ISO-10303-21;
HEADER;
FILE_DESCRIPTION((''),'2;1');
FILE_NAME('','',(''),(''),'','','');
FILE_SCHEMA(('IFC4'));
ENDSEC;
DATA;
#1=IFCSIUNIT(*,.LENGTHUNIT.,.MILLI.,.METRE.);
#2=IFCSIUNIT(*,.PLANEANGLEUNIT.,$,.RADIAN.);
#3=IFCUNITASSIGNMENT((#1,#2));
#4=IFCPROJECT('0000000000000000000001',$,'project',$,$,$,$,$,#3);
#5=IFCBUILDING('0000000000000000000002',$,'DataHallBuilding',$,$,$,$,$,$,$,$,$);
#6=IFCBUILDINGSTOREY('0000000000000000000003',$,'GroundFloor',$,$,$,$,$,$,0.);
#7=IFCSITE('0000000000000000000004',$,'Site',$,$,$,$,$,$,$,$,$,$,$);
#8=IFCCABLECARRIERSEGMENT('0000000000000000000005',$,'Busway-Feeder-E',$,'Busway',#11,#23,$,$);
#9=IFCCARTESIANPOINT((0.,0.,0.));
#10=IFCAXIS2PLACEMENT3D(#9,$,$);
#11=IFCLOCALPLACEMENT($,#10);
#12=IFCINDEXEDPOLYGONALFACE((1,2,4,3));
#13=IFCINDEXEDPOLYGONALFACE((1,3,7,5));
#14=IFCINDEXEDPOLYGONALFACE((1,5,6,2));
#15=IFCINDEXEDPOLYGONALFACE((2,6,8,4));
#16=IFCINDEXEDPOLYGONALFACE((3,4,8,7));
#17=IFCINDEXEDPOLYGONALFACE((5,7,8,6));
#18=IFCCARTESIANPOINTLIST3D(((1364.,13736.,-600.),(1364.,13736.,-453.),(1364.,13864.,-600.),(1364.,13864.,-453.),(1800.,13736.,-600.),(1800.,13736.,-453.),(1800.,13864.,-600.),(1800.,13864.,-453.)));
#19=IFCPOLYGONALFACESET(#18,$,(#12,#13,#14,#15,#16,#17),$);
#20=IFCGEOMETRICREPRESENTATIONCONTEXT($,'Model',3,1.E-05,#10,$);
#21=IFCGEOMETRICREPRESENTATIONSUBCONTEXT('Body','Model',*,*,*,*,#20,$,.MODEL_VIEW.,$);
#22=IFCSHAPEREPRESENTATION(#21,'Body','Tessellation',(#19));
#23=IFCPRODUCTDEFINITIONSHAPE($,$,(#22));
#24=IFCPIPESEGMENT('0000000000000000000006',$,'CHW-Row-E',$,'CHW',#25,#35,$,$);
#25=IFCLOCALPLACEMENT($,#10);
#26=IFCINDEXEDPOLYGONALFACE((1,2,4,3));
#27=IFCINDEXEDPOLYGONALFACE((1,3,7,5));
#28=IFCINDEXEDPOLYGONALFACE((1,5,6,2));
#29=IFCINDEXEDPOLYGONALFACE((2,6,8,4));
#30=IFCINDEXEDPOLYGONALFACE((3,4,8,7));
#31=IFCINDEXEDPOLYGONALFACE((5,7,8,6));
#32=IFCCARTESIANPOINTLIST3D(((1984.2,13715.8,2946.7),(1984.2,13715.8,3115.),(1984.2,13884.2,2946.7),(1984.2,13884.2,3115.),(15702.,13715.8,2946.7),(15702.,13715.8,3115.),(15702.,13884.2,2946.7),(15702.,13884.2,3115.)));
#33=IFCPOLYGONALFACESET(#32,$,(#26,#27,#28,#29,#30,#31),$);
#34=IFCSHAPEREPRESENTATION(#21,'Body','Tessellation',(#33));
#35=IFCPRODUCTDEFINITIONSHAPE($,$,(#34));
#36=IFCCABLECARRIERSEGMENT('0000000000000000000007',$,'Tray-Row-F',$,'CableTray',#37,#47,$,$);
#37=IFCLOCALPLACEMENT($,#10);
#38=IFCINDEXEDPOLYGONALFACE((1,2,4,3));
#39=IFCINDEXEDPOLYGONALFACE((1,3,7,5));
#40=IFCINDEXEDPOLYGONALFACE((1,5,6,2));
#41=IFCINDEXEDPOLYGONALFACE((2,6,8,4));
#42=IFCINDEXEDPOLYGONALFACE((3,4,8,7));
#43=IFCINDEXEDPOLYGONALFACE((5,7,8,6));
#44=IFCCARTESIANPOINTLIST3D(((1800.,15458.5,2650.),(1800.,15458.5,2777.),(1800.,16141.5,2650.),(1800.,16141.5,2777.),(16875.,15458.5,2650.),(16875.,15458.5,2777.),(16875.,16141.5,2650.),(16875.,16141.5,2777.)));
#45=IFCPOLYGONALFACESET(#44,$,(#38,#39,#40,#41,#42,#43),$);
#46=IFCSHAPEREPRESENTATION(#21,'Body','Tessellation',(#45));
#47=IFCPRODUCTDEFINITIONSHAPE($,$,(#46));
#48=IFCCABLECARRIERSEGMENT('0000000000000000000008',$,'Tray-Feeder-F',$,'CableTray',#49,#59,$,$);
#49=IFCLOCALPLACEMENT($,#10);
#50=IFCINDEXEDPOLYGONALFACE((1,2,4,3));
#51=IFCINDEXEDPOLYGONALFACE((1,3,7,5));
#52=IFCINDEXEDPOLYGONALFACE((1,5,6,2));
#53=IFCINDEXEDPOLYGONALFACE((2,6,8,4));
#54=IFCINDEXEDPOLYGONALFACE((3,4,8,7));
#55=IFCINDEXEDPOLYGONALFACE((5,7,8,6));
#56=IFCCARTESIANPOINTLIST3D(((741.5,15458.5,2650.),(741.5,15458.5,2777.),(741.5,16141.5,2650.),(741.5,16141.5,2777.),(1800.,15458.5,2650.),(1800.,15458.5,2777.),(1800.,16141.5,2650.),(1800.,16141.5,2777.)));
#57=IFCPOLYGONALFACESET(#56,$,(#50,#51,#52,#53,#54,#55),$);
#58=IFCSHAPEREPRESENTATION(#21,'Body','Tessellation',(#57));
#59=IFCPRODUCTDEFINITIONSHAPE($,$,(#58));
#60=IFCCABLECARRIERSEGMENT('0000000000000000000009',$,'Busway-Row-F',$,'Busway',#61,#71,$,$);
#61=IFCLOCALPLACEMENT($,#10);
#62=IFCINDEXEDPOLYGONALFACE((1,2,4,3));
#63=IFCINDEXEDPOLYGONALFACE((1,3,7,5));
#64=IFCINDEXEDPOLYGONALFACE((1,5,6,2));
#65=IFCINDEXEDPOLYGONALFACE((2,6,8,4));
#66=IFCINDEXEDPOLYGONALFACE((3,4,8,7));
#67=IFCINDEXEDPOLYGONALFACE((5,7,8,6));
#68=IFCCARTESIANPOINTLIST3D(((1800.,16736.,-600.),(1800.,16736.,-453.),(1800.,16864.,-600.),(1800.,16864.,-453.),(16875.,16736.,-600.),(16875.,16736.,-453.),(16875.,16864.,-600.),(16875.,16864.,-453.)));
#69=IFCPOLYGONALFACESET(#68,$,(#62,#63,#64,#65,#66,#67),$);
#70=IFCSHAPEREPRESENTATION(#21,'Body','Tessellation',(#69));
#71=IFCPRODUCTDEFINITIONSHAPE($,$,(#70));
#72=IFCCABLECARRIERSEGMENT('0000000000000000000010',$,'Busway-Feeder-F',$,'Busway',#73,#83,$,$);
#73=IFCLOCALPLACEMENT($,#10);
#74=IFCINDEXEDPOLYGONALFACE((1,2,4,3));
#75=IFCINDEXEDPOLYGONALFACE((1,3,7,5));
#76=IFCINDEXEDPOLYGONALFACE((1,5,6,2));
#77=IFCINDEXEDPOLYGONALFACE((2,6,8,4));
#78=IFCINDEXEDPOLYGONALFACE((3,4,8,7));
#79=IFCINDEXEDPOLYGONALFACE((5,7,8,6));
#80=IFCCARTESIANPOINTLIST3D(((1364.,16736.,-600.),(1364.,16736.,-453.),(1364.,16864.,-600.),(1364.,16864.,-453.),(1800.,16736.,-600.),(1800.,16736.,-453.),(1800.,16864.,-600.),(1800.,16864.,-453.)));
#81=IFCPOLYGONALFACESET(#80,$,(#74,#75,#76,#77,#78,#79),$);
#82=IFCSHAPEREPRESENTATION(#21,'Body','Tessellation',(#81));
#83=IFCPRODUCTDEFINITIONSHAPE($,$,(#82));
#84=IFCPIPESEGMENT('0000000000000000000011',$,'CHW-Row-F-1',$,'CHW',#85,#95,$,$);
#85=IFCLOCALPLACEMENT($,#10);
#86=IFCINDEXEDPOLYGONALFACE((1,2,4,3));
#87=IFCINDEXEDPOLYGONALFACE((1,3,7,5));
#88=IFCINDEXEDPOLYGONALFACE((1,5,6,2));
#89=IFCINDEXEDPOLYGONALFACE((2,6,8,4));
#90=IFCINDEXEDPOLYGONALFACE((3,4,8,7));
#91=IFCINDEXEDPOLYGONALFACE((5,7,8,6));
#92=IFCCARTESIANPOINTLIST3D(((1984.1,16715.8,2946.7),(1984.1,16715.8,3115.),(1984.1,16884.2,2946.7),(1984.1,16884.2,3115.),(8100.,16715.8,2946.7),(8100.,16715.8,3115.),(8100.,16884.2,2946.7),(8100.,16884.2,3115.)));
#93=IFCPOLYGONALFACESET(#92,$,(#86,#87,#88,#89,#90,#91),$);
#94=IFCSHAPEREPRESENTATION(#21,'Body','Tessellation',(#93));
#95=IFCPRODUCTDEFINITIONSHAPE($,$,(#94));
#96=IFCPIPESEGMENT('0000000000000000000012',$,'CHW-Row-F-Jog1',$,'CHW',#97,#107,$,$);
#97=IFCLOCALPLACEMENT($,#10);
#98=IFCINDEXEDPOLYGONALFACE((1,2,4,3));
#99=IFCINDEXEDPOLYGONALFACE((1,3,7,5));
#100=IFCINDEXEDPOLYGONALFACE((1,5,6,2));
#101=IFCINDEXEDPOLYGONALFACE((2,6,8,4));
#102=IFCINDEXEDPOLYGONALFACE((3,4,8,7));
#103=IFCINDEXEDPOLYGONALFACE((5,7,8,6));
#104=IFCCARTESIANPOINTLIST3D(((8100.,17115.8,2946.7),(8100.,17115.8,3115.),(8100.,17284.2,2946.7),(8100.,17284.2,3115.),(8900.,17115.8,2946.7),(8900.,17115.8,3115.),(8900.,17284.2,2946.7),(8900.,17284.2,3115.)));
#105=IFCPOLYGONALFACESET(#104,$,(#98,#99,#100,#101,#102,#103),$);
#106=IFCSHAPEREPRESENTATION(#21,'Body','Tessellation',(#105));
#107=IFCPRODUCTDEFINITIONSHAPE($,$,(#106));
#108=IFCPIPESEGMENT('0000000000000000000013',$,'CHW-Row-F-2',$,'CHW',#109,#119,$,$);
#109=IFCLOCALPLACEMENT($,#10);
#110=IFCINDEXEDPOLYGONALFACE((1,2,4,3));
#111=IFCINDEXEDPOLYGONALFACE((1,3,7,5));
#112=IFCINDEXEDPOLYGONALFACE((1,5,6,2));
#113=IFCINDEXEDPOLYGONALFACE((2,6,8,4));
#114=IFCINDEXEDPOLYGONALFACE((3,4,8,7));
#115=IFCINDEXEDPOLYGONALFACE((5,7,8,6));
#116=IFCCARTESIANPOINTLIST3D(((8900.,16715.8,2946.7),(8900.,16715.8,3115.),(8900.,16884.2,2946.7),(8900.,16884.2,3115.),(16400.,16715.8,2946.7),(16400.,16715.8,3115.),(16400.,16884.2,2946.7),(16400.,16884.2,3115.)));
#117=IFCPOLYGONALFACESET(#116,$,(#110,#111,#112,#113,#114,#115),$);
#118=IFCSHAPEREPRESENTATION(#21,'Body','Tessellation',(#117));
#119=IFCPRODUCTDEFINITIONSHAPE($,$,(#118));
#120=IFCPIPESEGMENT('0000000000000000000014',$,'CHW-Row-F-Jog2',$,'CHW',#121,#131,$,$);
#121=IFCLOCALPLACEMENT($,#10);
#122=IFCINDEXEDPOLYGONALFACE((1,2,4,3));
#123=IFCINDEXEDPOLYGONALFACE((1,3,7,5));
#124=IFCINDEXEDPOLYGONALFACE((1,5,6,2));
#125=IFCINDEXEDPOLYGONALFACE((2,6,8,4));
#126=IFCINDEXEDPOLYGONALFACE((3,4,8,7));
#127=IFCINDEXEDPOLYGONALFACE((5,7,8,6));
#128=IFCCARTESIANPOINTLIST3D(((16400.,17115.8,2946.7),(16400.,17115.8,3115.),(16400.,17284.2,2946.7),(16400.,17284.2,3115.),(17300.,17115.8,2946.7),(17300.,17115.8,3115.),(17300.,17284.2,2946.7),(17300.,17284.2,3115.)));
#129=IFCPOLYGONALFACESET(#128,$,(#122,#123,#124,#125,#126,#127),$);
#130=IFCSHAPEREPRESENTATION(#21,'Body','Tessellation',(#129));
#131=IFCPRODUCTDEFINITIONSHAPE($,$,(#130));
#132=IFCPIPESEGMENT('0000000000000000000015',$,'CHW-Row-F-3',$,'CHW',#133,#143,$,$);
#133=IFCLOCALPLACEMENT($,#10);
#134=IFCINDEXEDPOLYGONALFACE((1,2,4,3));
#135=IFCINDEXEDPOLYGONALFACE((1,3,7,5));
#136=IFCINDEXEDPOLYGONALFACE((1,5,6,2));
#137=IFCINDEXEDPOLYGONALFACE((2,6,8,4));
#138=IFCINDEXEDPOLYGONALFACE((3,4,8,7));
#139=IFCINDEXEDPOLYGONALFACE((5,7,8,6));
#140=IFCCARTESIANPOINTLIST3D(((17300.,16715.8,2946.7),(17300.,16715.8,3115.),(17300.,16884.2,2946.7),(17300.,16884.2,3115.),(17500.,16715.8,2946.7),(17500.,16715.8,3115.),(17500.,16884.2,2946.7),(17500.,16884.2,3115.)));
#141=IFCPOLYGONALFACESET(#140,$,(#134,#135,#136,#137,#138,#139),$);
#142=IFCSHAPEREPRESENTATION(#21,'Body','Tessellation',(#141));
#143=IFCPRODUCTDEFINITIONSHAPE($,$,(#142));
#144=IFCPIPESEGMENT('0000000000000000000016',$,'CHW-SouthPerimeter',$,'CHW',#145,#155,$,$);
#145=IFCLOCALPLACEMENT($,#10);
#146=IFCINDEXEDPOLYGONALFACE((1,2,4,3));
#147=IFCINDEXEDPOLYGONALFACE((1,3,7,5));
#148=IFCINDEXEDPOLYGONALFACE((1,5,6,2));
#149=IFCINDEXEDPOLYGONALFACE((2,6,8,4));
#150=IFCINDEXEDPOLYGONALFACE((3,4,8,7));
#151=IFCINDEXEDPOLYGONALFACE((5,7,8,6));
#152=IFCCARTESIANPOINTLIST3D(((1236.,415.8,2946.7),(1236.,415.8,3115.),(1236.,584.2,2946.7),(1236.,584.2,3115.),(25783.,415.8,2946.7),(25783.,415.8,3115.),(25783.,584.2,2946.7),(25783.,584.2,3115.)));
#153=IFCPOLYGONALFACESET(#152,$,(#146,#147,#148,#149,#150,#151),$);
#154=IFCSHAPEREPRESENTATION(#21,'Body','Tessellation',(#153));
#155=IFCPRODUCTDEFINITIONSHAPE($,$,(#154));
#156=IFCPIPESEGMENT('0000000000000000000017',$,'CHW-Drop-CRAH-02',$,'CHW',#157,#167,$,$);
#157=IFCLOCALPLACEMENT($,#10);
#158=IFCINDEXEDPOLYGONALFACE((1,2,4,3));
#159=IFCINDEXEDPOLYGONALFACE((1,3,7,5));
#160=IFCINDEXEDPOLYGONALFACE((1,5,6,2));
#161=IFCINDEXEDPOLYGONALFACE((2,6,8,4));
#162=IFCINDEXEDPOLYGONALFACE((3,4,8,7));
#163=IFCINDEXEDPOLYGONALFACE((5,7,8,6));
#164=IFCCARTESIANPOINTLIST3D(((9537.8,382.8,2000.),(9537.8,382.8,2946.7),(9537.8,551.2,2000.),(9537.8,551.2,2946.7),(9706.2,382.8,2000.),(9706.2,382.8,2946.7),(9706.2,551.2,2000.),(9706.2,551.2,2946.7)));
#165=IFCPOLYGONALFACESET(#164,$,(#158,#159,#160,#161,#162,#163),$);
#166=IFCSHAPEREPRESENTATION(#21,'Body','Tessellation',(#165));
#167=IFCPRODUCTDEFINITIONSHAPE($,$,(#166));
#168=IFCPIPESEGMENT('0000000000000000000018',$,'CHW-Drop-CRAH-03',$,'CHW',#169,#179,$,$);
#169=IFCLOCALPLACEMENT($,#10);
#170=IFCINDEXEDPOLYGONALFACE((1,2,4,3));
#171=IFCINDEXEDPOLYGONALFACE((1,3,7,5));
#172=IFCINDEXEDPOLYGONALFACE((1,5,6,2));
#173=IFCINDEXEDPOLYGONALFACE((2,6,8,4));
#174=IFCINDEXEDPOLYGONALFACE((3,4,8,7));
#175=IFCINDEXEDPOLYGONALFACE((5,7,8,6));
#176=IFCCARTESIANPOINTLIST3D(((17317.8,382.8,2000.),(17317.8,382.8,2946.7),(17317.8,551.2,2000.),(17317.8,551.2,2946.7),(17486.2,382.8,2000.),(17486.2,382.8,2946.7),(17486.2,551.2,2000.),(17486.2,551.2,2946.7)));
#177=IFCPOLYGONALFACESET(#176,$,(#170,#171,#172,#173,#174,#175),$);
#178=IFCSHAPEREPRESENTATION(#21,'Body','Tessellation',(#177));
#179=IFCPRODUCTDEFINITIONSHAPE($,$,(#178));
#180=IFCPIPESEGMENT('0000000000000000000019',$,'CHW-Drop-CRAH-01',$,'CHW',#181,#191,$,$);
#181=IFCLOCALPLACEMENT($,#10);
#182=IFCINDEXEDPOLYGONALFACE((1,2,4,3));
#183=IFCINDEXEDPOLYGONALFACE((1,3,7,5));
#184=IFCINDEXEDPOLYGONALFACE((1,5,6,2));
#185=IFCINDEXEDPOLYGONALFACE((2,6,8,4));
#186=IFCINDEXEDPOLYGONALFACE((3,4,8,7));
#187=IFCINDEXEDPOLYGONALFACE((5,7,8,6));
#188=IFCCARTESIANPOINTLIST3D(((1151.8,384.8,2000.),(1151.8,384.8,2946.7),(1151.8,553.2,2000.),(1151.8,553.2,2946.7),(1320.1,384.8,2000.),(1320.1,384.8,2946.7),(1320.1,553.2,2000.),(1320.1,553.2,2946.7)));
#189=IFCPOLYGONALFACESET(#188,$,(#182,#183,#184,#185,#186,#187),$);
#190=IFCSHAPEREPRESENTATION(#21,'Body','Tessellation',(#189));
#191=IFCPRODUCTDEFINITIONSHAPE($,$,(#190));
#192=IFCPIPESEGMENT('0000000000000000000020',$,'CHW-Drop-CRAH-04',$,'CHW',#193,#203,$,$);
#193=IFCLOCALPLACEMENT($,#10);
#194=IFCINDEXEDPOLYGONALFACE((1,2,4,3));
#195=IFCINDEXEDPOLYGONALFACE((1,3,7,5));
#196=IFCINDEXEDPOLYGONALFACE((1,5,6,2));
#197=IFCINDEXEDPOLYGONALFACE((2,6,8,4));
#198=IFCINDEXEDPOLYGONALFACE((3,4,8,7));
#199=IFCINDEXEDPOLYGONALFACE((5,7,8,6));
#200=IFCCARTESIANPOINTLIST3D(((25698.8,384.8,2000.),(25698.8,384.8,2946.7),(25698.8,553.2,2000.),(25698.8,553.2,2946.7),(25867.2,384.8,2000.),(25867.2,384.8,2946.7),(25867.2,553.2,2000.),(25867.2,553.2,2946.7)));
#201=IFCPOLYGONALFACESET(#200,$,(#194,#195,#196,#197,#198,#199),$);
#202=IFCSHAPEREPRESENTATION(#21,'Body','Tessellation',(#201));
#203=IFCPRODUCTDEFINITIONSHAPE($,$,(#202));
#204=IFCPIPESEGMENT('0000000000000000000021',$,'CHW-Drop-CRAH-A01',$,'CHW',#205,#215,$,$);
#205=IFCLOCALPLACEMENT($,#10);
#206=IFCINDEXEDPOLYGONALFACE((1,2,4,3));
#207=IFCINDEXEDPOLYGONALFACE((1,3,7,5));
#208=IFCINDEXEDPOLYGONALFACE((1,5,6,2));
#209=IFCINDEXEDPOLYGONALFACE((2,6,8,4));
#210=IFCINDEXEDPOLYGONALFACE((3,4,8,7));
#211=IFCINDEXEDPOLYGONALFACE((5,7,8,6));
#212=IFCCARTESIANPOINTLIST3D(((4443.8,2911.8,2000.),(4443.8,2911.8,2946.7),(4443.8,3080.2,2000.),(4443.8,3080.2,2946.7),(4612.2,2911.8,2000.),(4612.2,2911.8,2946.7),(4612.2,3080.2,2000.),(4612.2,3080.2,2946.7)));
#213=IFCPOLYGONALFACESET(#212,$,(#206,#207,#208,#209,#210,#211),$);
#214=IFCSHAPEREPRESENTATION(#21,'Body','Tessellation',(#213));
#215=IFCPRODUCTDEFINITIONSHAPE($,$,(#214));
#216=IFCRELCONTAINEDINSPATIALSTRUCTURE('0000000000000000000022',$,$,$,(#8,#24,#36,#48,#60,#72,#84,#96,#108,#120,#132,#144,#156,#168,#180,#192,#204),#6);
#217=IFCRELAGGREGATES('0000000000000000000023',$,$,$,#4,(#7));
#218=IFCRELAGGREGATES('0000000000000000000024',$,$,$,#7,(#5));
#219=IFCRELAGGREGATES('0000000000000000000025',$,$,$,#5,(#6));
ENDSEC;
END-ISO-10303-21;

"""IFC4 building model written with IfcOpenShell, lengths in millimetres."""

from ifc_helpers import new_model, si_unit, frame, origin, place, context, subcontext, project, spatial, rectangle, extrude, element, save


model = new_model("IFC4")

# Units and contexts
model_context = context("Model", 3, precision=1e-05, world=origin())
body_context = subcontext(model_context, "Body", "Model", "MODEL_VIEW")
ifc_project = project(units=[si_unit("LENGTHUNIT", "METRE", prefix="MILLI"), si_unit("PLANEANGLEUNIT", "RADIAN")])

# Site, building, storey
site = spatial("IfcSite", under=ifc_project, Name="Site")
building = spatial("IfcBuilding", under=site, Name="DataHallBuilding")
storey = spatial("IfcBuildingStorey", under=building, Name="GroundFloor", Elevation=0.0)

# Cable carrier segment
cable_carrier_segment_1_placement = place(None, origin())
element("IfcCableCarrierSegment", 1, at=cable_carrier_segment_1_placement, inside=storey, Name="Busway-Feeder-E", ObjectType="Busway", context=body_context, shape_type="SweptSolid", body=[
    extrude(rectangle(XDim=436.0, YDim=128.0), frame((1582.0, 13800.0, -600.0), z_axis=(0.0, 0.0, 1.0), x_axis=(1.0, 0.0, 0.0)), (0.0, 0.0, 1.0), 147.0),
])

# Pipe segment
pipe_segment_1_placement = place(None, origin())
element("IfcPipeSegment", 2, at=pipe_segment_1_placement, inside=storey, Name="CHW-Row-E", ObjectType="CHW", context=body_context, shape_type="SweptSolid", body=[
    extrude(rectangle(XDim=13717.9, YDim=168.3), frame((8843.1, 13800.0, 2946.7), z_axis=(0.0, 0.0, 1.0), x_axis=(1.0, 0.0, 0.0)), (0.0, 0.0, 1.0), 168.3),
])

# Cable carrier segments
cable_carrier_segment_2_placement = place(None, origin())
element("IfcCableCarrierSegment", 3, at=cable_carrier_segment_2_placement, inside=storey, Name="Tray-Row-F", ObjectType="CableTray", context=body_context, shape_type="SweptSolid", body=[
    extrude(rectangle(XDim=15075.0, YDim=683.0), frame((9337.5, 15800.0, 2650.0), z_axis=(0.0, 0.0, 1.0), x_axis=(1.0, 0.0, 0.0)), (0.0, 0.0, 1.0), 127.0),
])
cable_carrier_segment_3_placement = place(None, origin())
element("IfcCableCarrierSegment", 4, at=cable_carrier_segment_3_placement, inside=storey, Name="Tray-Feeder-F", ObjectType="CableTray", context=body_context, shape_type="SweptSolid", body=[
    extrude(rectangle(XDim=1058.5, YDim=683.0), frame((1270.8, 15800.0, 2650.0), z_axis=(0.0, 0.0, 1.0), x_axis=(1.0, 0.0, 0.0)), (0.0, 0.0, 1.0), 127.0),
])
cable_carrier_segment_4_placement = place(None, origin())
element("IfcCableCarrierSegment", 5, at=cable_carrier_segment_4_placement, inside=storey, Name="Busway-Row-F", ObjectType="Busway", context=body_context, shape_type="SweptSolid", body=[
    extrude(rectangle(XDim=15075.0, YDim=128.0), frame((9337.5, 16800.0, -600.0), z_axis=(0.0, 0.0, 1.0), x_axis=(1.0, 0.0, 0.0)), (0.0, 0.0, 1.0), 147.0),
])
cable_carrier_segment_5_placement = place(None, origin())
element("IfcCableCarrierSegment", 6, at=cable_carrier_segment_5_placement, inside=storey, Name="Busway-Feeder-F", ObjectType="Busway", context=body_context, shape_type="SweptSolid", body=[
    extrude(rectangle(XDim=436.0, YDim=128.0), frame((1582.0, 16800.0, -600.0), z_axis=(0.0, 0.0, 1.0), x_axis=(1.0, 0.0, 0.0)), (0.0, 0.0, 1.0), 147.0),
])

# Pipe segments
pipe_segment_2_placement = place(None, origin())
element("IfcPipeSegment", 7, at=pipe_segment_2_placement, inside=storey, Name="CHW-Row-F-1", ObjectType="CHW", context=body_context, shape_type="SweptSolid", body=[
    extrude(rectangle(XDim=6115.9, YDim=168.3), frame((5042.1, 16800.0, 2946.7), z_axis=(0.0, 0.0, 1.0), x_axis=(1.0, 0.0, 0.0)), (0.0, 0.0, 1.0), 168.3),
])
pipe_segment_3_placement = place(None, origin())
element("IfcPipeSegment", 8, at=pipe_segment_3_placement, inside=storey, Name="CHW-Row-F-Jog1", ObjectType="CHW", context=body_context, shape_type="SweptSolid", body=[
    extrude(rectangle(XDim=800.0, YDim=168.3), frame((8500.0, 17200.0, 2946.7), z_axis=(0.0, 0.0, 1.0), x_axis=(1.0, 0.0, 0.0)), (0.0, 0.0, 1.0), 168.3),
])
pipe_segment_4_placement = place(None, origin())
element("IfcPipeSegment", 9, at=pipe_segment_4_placement, inside=storey, Name="CHW-Row-F-2", ObjectType="CHW", context=body_context, shape_type="SweptSolid", body=[
    extrude(rectangle(XDim=7500.0, YDim=168.3), frame((12650.0, 16800.0, 2946.7), z_axis=(0.0, 0.0, 1.0), x_axis=(1.0, 0.0, 0.0)), (0.0, 0.0, 1.0), 168.3),
])
pipe_segment_5_placement = place(None, origin())
element("IfcPipeSegment", 10, at=pipe_segment_5_placement, inside=storey, Name="CHW-Row-F-Jog2", ObjectType="CHW", context=body_context, shape_type="SweptSolid", body=[
    extrude(rectangle(XDim=900.0, YDim=168.3), frame((16850.0, 17200.0, 2946.7), z_axis=(0.0, 0.0, 1.0), x_axis=(1.0, 0.0, 0.0)), (0.0, 0.0, 1.0), 168.3),
])
pipe_segment_6_placement = place(None, origin())
element("IfcPipeSegment", 11, at=pipe_segment_6_placement, inside=storey, Name="CHW-Row-F-3", ObjectType="CHW", context=body_context, shape_type="SweptSolid", body=[
    extrude(rectangle(XDim=200.0, YDim=168.3), frame((17400.0, 16800.0, 2946.7), z_axis=(0.0, 0.0, 1.0), x_axis=(1.0, 0.0, 0.0)), (0.0, 0.0, 1.0), 168.3),
])
pipe_segment_7_placement = place(None, origin())
element("IfcPipeSegment", 12, at=pipe_segment_7_placement, inside=storey, Name="CHW-SouthPerimeter", ObjectType="CHW", context=body_context, shape_type="SweptSolid", body=[
    extrude(rectangle(XDim=24547.0, YDim=168.3), frame((13509.5, 500.0, 2946.7), z_axis=(0.0, 0.0, 1.0), x_axis=(1.0, 0.0, 0.0)), (0.0, 0.0, 1.0), 168.3),
])
pipe_segment_8_placement = place(None, origin())
element("IfcPipeSegment", 13, at=pipe_segment_8_placement, inside=storey, Name="CHW-Drop-CRAH-02", ObjectType="CHW", context=body_context, shape_type="SweptSolid", body=[
    extrude(rectangle(XDim=168.3, YDim=168.3), frame((9622.0, 467.0, 2000.0), z_axis=(0.0, 0.0, 1.0), x_axis=(1.0, 0.0, 0.0)), (0.0, 0.0, 1.0), 946.7),
])
pipe_segment_9_placement = place(None, origin())
element("IfcPipeSegment", 14, at=pipe_segment_9_placement, inside=storey, Name="CHW-Drop-CRAH-03", ObjectType="CHW", context=body_context, shape_type="SweptSolid", body=[
    extrude(rectangle(XDim=168.3, YDim=168.3), frame((17402.0, 467.0, 2000.0), z_axis=(0.0, 0.0, 1.0), x_axis=(1.0, 0.0, 0.0)), (0.0, 0.0, 1.0), 946.7),
])
pipe_segment_10_placement = place(None, origin())
element("IfcPipeSegment", 15, at=pipe_segment_10_placement, inside=storey, Name="CHW-Drop-CRAH-01", ObjectType="CHW", context=body_context, shape_type="SweptSolid", body=[
    extrude(rectangle(XDim=168.3, YDim=168.3), frame((1236.0, 469.0, 2000.0), z_axis=(0.0, 0.0, 1.0), x_axis=(1.0, 0.0, 0.0)), (0.0, 0.0, 1.0), 946.7),
])
pipe_segment_11_placement = place(None, origin())
element("IfcPipeSegment", 16, at=pipe_segment_11_placement, inside=storey, Name="CHW-Drop-CRAH-04", ObjectType="CHW", context=body_context, shape_type="SweptSolid", body=[
    extrude(rectangle(XDim=168.3, YDim=168.3), frame((25783.0, 469.0, 2000.0), z_axis=(0.0, 0.0, 1.0), x_axis=(1.0, 0.0, 0.0)), (0.0, 0.0, 1.0), 946.7),
])
pipe_segment_12_placement = place(None, origin())
element("IfcPipeSegment", 17, at=pipe_segment_12_placement, inside=storey, Name="CHW-Drop-CRAH-A01", ObjectType="CHW", context=body_context, shape_type="SweptSolid", body=[
    extrude(rectangle(XDim=168.3, YDim=168.3), frame((4528.0, 2996.0, 2000.0), z_axis=(0.0, 0.0, 1.0), x_axis=(1.0, 0.0, 0.0)), (0.0, 0.0, 1.0), 946.7),
])

save(model, "model.ifc")
